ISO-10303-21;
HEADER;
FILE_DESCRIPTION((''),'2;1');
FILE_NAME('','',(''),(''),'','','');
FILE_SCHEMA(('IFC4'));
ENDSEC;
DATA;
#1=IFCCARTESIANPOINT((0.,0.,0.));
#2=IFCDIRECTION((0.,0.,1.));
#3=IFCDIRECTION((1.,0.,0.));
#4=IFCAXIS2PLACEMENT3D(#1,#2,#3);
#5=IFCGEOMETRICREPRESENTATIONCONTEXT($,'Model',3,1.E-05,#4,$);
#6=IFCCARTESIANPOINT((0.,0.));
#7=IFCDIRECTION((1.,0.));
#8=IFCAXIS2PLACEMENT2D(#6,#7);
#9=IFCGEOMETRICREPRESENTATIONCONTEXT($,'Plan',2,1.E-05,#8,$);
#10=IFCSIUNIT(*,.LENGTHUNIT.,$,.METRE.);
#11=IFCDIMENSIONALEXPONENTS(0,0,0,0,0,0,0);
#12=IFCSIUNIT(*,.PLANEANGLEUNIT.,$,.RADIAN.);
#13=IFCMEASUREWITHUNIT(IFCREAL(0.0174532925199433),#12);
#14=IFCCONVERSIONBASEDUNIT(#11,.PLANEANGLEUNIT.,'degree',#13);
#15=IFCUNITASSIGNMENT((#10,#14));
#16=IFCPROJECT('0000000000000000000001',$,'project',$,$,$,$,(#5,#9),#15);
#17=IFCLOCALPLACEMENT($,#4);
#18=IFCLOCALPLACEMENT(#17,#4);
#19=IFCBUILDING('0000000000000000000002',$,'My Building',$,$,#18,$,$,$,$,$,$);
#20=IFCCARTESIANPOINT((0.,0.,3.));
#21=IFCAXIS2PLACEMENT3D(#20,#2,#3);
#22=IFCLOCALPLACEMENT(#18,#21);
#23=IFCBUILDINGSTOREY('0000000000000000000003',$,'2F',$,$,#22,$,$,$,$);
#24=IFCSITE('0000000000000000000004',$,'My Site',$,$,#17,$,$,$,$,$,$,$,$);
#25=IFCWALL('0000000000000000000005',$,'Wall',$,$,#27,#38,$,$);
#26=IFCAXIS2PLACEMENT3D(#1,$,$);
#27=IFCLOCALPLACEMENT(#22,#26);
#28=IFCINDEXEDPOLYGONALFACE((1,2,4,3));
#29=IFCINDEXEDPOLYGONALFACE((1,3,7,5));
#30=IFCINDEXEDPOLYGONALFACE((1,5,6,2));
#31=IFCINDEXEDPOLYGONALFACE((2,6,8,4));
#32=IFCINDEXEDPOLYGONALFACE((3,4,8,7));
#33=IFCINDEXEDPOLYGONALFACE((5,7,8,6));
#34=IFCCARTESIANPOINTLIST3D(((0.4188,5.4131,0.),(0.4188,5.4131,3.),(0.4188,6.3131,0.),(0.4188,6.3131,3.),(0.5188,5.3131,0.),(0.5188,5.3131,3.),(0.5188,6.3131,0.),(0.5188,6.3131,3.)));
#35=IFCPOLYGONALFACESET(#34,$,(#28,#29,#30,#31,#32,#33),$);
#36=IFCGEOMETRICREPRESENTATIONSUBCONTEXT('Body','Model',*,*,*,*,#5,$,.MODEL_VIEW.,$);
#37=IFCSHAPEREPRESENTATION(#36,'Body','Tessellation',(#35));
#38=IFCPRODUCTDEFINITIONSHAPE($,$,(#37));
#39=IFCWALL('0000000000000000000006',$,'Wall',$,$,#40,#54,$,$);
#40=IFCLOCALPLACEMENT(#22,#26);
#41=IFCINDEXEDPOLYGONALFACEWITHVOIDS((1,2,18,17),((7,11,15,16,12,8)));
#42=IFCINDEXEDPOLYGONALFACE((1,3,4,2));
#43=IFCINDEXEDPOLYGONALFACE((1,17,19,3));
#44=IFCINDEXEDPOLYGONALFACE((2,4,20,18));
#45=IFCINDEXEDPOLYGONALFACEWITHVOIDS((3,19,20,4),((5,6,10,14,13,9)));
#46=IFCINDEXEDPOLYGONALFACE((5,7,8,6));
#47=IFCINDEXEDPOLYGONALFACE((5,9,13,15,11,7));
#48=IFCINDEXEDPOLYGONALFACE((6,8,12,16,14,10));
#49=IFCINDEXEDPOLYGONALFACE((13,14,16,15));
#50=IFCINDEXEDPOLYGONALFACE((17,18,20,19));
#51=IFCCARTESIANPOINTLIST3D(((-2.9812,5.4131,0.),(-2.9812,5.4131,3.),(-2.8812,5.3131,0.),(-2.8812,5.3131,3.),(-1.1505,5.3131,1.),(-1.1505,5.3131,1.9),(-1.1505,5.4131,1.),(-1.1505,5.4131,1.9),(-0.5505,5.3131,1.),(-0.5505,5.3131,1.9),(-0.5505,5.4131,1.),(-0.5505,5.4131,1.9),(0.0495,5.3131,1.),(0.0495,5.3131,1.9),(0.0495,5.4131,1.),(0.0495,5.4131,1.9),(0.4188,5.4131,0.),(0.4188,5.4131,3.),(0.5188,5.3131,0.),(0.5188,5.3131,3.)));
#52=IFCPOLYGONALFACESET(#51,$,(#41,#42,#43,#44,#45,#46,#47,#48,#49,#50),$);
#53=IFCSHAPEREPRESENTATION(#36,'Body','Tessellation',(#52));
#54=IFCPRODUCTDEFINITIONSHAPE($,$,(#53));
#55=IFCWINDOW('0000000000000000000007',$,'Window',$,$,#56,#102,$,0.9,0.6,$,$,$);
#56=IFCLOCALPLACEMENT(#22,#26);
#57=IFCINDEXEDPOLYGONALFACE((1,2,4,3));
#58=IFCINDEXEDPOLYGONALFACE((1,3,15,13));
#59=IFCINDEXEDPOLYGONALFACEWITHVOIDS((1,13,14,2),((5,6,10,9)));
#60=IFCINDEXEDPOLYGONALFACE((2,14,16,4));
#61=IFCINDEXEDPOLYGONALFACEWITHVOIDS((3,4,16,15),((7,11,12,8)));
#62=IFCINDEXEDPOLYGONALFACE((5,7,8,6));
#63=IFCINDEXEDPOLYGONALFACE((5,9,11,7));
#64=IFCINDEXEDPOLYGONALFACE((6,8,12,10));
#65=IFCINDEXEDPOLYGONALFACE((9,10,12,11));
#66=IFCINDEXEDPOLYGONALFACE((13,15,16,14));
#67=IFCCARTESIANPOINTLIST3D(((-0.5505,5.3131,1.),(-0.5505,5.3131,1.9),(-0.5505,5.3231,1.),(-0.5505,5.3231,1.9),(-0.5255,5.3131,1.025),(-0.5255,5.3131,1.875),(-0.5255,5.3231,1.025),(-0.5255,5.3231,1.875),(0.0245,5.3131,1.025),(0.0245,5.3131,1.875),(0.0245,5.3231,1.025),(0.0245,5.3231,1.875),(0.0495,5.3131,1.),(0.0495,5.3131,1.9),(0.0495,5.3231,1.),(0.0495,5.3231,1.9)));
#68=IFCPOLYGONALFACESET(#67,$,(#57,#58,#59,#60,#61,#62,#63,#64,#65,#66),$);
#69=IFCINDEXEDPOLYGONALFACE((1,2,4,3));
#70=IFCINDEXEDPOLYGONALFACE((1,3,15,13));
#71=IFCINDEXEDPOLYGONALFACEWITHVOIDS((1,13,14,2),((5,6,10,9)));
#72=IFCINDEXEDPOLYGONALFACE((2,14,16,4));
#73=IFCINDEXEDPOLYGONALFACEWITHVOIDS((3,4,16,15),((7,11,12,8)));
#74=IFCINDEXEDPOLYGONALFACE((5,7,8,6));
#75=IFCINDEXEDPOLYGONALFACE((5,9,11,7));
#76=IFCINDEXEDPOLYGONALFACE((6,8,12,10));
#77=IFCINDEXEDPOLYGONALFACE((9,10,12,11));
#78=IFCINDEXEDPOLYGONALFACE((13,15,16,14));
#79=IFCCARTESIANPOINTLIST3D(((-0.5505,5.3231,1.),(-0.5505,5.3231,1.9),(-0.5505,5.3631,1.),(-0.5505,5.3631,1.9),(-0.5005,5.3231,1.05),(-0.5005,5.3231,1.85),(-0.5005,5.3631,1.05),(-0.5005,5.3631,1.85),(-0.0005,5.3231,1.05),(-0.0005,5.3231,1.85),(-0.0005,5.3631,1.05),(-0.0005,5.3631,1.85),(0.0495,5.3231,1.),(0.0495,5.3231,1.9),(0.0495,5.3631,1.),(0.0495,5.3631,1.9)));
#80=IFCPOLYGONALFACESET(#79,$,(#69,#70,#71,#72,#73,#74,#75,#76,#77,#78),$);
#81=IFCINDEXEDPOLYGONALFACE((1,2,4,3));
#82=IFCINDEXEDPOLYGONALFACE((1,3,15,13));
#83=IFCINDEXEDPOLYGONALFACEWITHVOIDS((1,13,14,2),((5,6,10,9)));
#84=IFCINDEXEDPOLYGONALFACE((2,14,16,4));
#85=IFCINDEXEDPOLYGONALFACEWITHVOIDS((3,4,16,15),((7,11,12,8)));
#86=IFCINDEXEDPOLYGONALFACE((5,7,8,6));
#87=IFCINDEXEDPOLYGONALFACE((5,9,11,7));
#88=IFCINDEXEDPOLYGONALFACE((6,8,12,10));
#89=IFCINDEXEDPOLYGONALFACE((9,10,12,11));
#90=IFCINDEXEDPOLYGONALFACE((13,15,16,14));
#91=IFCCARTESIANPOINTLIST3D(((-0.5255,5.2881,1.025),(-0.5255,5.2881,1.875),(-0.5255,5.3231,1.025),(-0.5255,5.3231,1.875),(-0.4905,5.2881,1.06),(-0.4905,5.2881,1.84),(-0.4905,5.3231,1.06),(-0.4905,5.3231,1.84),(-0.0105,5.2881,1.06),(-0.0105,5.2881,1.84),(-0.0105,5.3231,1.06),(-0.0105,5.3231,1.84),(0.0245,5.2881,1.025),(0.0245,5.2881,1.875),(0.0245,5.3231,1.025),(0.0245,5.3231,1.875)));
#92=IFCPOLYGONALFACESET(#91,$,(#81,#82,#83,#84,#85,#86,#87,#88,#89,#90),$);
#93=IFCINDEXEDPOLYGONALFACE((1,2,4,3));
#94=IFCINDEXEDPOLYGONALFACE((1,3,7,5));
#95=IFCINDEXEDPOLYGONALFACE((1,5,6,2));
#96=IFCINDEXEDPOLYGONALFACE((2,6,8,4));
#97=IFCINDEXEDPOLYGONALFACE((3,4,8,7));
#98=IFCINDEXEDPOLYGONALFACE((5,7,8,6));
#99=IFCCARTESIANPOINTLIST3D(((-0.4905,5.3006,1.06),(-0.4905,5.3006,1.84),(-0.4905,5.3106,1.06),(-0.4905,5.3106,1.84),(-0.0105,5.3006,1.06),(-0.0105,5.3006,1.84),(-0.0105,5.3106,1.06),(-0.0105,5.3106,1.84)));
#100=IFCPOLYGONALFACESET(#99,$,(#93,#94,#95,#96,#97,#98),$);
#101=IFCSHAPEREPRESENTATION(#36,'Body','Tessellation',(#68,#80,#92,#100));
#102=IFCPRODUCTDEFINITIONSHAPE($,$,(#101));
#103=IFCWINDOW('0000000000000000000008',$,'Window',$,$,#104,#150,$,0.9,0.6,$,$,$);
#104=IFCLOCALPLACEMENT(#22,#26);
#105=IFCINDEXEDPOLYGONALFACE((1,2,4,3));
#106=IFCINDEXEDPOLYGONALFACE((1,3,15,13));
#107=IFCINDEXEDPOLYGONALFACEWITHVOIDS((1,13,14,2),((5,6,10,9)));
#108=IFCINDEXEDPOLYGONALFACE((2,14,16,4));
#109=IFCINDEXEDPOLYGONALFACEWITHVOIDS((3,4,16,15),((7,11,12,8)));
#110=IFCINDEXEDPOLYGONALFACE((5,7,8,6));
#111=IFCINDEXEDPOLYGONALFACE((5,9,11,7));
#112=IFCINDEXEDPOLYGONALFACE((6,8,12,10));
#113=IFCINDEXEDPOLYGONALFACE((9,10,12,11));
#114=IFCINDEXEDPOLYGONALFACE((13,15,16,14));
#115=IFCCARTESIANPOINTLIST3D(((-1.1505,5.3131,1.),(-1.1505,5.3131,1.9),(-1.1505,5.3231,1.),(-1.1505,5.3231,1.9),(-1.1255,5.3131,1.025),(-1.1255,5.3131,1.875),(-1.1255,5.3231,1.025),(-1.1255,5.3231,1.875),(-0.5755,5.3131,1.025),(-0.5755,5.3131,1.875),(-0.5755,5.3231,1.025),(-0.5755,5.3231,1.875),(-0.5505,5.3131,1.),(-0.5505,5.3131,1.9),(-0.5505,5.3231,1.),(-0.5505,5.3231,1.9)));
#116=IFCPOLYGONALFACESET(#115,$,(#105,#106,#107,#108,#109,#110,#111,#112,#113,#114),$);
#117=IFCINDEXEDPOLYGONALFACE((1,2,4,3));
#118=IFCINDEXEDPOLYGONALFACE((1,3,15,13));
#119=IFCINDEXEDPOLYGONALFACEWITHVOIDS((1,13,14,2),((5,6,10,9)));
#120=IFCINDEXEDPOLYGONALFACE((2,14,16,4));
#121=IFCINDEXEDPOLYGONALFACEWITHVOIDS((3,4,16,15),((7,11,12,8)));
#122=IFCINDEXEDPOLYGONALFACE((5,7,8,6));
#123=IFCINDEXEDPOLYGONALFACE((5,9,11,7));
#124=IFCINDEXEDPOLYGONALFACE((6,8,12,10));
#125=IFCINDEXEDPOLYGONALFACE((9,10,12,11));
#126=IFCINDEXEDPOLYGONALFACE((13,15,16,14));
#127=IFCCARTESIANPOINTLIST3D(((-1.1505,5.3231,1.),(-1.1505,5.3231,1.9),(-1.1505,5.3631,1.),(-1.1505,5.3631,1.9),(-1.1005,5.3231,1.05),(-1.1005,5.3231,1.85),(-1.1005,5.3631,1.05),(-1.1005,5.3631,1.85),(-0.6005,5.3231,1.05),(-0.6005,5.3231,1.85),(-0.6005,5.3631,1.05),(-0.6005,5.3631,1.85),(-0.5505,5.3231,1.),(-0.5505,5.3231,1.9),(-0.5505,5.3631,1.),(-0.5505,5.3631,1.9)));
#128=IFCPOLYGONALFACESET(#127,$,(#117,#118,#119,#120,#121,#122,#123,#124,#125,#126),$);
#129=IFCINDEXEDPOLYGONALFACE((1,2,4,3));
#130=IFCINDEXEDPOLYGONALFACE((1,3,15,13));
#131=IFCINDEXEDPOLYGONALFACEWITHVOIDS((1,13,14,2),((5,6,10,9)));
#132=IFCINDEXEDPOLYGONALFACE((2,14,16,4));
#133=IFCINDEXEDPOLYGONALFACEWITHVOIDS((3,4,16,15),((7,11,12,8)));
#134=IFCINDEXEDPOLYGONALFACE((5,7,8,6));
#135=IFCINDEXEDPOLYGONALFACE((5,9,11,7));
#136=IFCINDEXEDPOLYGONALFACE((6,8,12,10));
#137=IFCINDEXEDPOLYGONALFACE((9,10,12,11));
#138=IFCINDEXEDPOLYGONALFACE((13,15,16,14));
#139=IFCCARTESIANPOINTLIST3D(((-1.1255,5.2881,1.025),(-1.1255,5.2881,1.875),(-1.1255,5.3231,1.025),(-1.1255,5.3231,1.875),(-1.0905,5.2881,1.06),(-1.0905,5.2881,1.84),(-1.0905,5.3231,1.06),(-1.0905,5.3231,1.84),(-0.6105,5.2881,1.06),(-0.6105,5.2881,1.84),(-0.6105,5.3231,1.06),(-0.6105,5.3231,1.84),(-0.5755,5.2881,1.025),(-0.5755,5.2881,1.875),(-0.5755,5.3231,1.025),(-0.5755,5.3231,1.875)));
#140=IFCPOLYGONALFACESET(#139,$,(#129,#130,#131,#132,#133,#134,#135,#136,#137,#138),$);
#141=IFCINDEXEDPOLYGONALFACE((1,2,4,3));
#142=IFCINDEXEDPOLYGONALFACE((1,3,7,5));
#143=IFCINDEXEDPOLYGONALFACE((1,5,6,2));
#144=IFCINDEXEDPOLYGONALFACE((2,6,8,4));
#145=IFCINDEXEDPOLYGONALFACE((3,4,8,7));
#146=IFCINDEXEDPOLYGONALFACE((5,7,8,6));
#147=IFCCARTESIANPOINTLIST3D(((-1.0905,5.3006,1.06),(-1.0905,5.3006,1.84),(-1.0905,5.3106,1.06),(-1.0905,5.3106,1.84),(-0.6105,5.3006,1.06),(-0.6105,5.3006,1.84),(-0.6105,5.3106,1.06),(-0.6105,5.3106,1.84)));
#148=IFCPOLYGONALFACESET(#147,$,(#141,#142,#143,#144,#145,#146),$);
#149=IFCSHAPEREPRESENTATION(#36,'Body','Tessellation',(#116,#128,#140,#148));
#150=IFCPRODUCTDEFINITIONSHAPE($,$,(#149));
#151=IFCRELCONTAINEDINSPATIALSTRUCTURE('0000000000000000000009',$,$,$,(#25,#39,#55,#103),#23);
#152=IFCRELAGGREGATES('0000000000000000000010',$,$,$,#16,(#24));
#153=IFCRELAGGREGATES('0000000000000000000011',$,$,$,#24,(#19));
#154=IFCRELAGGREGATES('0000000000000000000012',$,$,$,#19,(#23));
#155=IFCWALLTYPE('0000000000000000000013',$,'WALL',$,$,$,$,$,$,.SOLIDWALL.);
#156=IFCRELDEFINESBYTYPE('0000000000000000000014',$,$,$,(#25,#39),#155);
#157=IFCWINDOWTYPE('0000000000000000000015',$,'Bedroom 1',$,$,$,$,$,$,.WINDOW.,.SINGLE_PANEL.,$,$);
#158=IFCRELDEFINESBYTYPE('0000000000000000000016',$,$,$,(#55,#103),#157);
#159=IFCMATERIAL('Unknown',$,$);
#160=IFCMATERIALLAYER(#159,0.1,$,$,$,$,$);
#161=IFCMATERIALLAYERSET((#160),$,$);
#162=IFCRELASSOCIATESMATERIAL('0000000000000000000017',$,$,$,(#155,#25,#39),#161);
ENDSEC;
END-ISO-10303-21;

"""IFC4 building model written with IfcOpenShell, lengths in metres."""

from ifc_helpers import new_model, entity, si_unit, converted_unit, frame, origin_with_axes, origin_2d_with_axis, place, context, subcontext, project, spatial, line, indexed_curve, outline, extrude, shape, source, transform, mapped, material, layer, layer_set, layer_usage, type_object, type_shapes, element, fill, save


model = new_model("IFC4")

# Units and contexts
model_context = context("Model", 3, precision=1e-05, world=origin_with_axes())
plan_context = context("Plan", 2, precision=1e-05, world=origin_2d_with_axis())
body_context_1 = subcontext(model_context, "Body", "Model", "MODEL_VIEW")
body_context_2 = subcontext(plan_context, "Body", "Plan", "PLAN_VIEW")
ifc_project = project(units=[si_unit("LENGTHUNIT", "METRE"), converted_unit("PLANEANGLEUNIT", "degree", entity("IfcReal", 0.0174532925199433), si_unit("PLANEANGLEUNIT", "RADIAN"), dimensions=[0, 0, 0, 0, 0, 0, 0])], contexts=[model_context, plan_context])

# Site, building, storey
site_placement = place(None, origin_with_axes())
site = spatial("IfcSite", under=ifc_project, at=site_placement, Name="My Site")
building_placement = place(site_placement, origin_with_axes())
building = spatial("IfcBuilding", under=site, at=building_placement, Name="My Building")
storey_placement = place(building_placement, frame((0.0, 0.0, 3.0), z_axis=(0.0, 0.0, 1.0), x_axis=(1.0, 0.0, 0.0)))
storey = spatial("IfcBuildingStorey", under=building, at=storey_placement, Name="2F")

# Shared definitions
ifc_material = material(Name="Unknown")

# Wall
ifc_layer_1 = layer(ifc_material, 0.1)
ifc_layer_set_1 = layer_set([ifc_layer_1])
wall_type = type_object("IfcWallType", Name="WALL", PredefinedType="SOLIDWALL", material=ifc_layer_set_1)
ifc_layer_usage_1 = layer_usage(ifc_layer_set_1, "AXIS2", "POSITIVE", 0.0)
wall_1_placement = place(storey_placement, frame((0.4188, 6.3131, 0.0), z_axis=(0.0, 0.0, 1.0), x_axis=(0.0, -1.0, 0.0)))
element("IfcWall", 1, at=wall_1_placement, inside=storey, type_object=wall_type, material=ifc_layer_usage_1, Name="Wall", context=body_context_1, shape_type="SweptSolid", body=[
    extrude(outline(indexed_curve([(0.0, 0.0), (0.0, 0.1), (1.0, 0.1), (0.9, 0.0)], segments=[line(1, 2, 3, 4, 1)])), origin_with_axes(), (0.0, 0.0, 1.0), 3.0),
])

# Wall, openings, windows
ifc_layer_usage_2 = layer_usage(ifc_layer_set_1, "AXIS2", "POSITIVE", 0.0)
wall_2_placement = place(storey_placement, frame((0.4188, 5.4131, 0.0), z_axis=(0.0, 0.0, 1.0), x_axis=(-1.0, 0.0, 0.0)))
wall_2 = element("IfcWall", 2, at=wall_2_placement, inside=storey, type_object=wall_type, material=ifc_layer_usage_2, Name="Wall", context=body_context_1, shape_type="SweptSolid", body=[
    extrude(outline(indexed_curve([(0.0, 0.0), (-0.1, 0.1), (3.3, 0.1), (3.4, 0.0)], segments=[line(1, 2, 3, 4, 1)])), origin_with_axes(), (0.0, 0.0, 1.0), 3.0),
])
shared_shape_1 = source(origin_with_axes(), body_context_1, "Body", "SweptSolid", [
    extrude(outline(indexed_curve([(0.0, 0.0), (0.6, 0.0), (0.6, 0.9), (0.0, 0.9)], segments=[line(1, 2, 3, 4, 1)])), frame((0.0, -0.6, 0.0), z_axis=(0.0, -1.0, 0.0), x_axis=(1.0, 0.0, 0.0)), (0.0, 0.0, -1.0), 1.2),
])
opening_1_placement = place(wall_2_placement, frame((0.3694, 0.0, 1.0), z_axis=(0.0, 0.0, 1.0), x_axis=(1.0, 0.0, 0.0)))
opening_1 = element("IfcOpeningElement", 3, at=opening_1_placement, cuts=wall_2, PredefinedType="OPENING", context=body_context_1, shape_type="MappedRepresentation", body=[
    mapped(shared_shape_1, transform((0.0, 0.0, 0.0), x_axis=(1.0, 0.0, 0.0), y_axis=(0.0, 1.0, 0.0), z_axis=(0.0, 0.0, 1.0), scale=1.0)),
])
opening_2_placement = place(wall_2_placement, frame((0.9694, 0.0, 1.0), z_axis=(0.0, 0.0, 1.0), x_axis=(1.0, 0.0, 0.0)))
opening_2 = element("IfcOpeningElement", 4, at=opening_2_placement, cuts=wall_2, PredefinedType="OPENING", context=body_context_1, shape_type="MappedRepresentation", body=[
    mapped(shared_shape_1, transform((0.0, 0.0, 0.0), x_axis=(1.0, 0.0, 0.0), y_axis=(0.0, 1.0, 0.0), z_axis=(0.0, 0.0, 1.0), scale=1.0)),
])
window_type_1 = type_object("IfcWindowType", Name="Bedroom 1", PartitioningType="SINGLE_PANEL", PredefinedType="WINDOW")
shared_shape_2 = source(origin_with_axes(), body_context_1, "Body", "SweptSolid", [
    extrude(outline(indexed_curve([(0.0, 0.0), (0.6, 0.0), (0.6, 0.9), (0.0, 0.9)], segments=[line(1, 2, 3, 4, 1)]), holes=[indexed_curve([(0.025, 0.025), (0.575, 0.025), (0.575, 0.875), (0.025, 0.875)], segments=[line(1, 2, 3, 4, 1)])]), frame((0.0, 0.09, 0.0), z_axis=(0.0, -1.0, 0.0), x_axis=(1.0, 0.0, 0.0)), (0.0, 0.0, -1.0), 0.01),
    extrude(outline(indexed_curve([(0.0, 0.0), (0.6, 0.0), (0.6, 0.9), (0.0, 0.9)], segments=[line(1, 2, 3, 4, 1)]), holes=[indexed_curve([(0.05, 0.05), (0.55, 0.05), (0.55, 0.85), (0.05, 0.85)], segments=[line(1, 2, 3, 4, 1)])]), frame((0.0, 0.05, 0.0), z_axis=(0.0, -1.0, 0.0), x_axis=(1.0, 0.0, 0.0)), (0.0, 0.0, -1.0), 0.04),
    extrude(outline(indexed_curve([(0.0, 0.0), (0.55, 0.0), (0.55, 0.85), (0.0, 0.85)], segments=[line(1, 2, 3, 4, 1)]), holes=[indexed_curve([(0.035, 0.035), (0.515, 0.035), (0.515, 0.815), (0.035, 0.815)], segments=[line(1, 2, 3, 4, 1)])]), frame((0.025, 0.09, 0.025), z_axis=(0.0, -1.0, 0.0), x_axis=(1.0, 0.0, 0.0)), (0.0, 0.0, -1.0), 0.035),
    extrude(outline(indexed_curve([(0.035, 0.035), (0.515, 0.035), (0.515, 0.815), (0.035, 0.815)], segments=[line(1, 2, 3, 4, 1)])), frame((0.025, 0.1025, 0.025), z_axis=(0.0, -1.0, 0.0), x_axis=(1.0, 0.0, 0.0)), (0.0, 0.0, -1.0), 0.01),
])
shared_shape_3 = source(origin_with_axes(), body_context_2, "Body", "Curve2D", [
    entity("IfcIndexedPolyCurve", entity("IfcCartesianPointList2D", [[0.05, 0.05], [0.55, 0.05]])),
    entity("IfcIndexedPolyCurve", entity("IfcCartesianPointList2D", [[0.0, 0.1], [0.025, 0.1], [0.025, 0.09], [0.05, 0.09], [0.05, 0.05], [0.0, 0.05]]), [entity("IfcLineIndex", [1, 2, 3, 4, 5, 6, 1])]),
    entity("IfcIndexedPolyCurve", entity("IfcCartesianPointList2D", [[0.6, 0.1], [0.575, 0.1], [0.575, 0.09], [0.55, 0.09], [0.55, 0.05], [0.6, 0.05]]), [entity("IfcLineIndex", [1, 2, 3, 4, 5, 6, 1])]),
    entity("IfcIndexedPolyCurve", entity("IfcCartesianPointList2D", [[0.025, 0.09], [0.06, 0.09], [0.06, 0.125], [0.025, 0.125]]), [entity("IfcLineIndex", [1, 2, 3, 4, 1])]),
    entity("IfcIndexedPolyCurve", entity("IfcCartesianPointList2D", [[0.575, 0.09], [0.54, 0.09], [0.54, 0.125], [0.575, 0.125]]), [entity("IfcLineIndex", [1, 2, 3, 4, 1])]),
    entity("IfcIndexedPolyCurve", entity("IfcCartesianPointList2D", [[0.06, 0.09], [0.54, 0.09]])),
    entity("IfcIndexedPolyCurve", entity("IfcCartesianPointList2D", [[0.06, 0.125], [0.54, 0.125]])),
    entity("IfcIndexedPolyCurve", entity("IfcCartesianPointList2D", [[0.06, 0.1075], [0.54, 0.1075]])),
])
type_shapes(window_type_1, [shared_shape_2, shared_shape_3])
window_1_placement = place(opening_1_placement, frame((0.0, 0.0, 0.0), z_axis=(0.0, 0.0, 1.0), x_axis=(1.0, 0.0, 0.0)))
window_1 = element("IfcWindow", 5, at=window_1_placement, inside=storey, type_object=window_type_1, Name="Window", OverallHeight=0.9, OverallWidth=0.6, shapes=[
    shape(body_context_1, "Body", "MappedRepresentation", [mapped(shared_shape_2, transform((0.0, 0.0, 0.0), x_axis=(1.0, 0.0, 0.0), y_axis=(0.0, 1.0, 0.0), z_axis=(0.0, 0.0, 1.0), scale=1.0))]),
    shape(body_context_2, "Body", "MappedRepresentation", [mapped(shared_shape_3, transform((0.0, 0.0, 0.0), x_axis=(1.0, 0.0, 0.0), y_axis=(0.0, 1.0, 0.0), z_axis=(0.0, 0.0, 1.0), scale=1.0))]),
])
fill(opening_1, window_1)
window_2_placement = place(opening_2_placement, origin_with_axes())
window_2 = element("IfcWindow", 6, at=window_2_placement, inside=storey, type_object=window_type_1, Name="Window", OverallHeight=0.9, OverallWidth=0.6, shapes=[
    shape(body_context_1, "Body", "MappedRepresentation", [mapped(shared_shape_2, transform((0.0, 0.0, 0.0), x_axis=(1.0, 0.0, 0.0), y_axis=(0.0, 1.0, 0.0), z_axis=(0.0, 0.0, 1.0), scale=1.0))]),
    shape(body_context_2, "Body", "MappedRepresentation", [mapped(shared_shape_3, transform((0.0, 0.0, 0.0), x_axis=(1.0, 0.0, 0.0), y_axis=(0.0, 1.0, 0.0), z_axis=(0.0, 0.0, 1.0), scale=1.0))]),
])
fill(opening_2, window_2)

save(model, "model.ifc")
